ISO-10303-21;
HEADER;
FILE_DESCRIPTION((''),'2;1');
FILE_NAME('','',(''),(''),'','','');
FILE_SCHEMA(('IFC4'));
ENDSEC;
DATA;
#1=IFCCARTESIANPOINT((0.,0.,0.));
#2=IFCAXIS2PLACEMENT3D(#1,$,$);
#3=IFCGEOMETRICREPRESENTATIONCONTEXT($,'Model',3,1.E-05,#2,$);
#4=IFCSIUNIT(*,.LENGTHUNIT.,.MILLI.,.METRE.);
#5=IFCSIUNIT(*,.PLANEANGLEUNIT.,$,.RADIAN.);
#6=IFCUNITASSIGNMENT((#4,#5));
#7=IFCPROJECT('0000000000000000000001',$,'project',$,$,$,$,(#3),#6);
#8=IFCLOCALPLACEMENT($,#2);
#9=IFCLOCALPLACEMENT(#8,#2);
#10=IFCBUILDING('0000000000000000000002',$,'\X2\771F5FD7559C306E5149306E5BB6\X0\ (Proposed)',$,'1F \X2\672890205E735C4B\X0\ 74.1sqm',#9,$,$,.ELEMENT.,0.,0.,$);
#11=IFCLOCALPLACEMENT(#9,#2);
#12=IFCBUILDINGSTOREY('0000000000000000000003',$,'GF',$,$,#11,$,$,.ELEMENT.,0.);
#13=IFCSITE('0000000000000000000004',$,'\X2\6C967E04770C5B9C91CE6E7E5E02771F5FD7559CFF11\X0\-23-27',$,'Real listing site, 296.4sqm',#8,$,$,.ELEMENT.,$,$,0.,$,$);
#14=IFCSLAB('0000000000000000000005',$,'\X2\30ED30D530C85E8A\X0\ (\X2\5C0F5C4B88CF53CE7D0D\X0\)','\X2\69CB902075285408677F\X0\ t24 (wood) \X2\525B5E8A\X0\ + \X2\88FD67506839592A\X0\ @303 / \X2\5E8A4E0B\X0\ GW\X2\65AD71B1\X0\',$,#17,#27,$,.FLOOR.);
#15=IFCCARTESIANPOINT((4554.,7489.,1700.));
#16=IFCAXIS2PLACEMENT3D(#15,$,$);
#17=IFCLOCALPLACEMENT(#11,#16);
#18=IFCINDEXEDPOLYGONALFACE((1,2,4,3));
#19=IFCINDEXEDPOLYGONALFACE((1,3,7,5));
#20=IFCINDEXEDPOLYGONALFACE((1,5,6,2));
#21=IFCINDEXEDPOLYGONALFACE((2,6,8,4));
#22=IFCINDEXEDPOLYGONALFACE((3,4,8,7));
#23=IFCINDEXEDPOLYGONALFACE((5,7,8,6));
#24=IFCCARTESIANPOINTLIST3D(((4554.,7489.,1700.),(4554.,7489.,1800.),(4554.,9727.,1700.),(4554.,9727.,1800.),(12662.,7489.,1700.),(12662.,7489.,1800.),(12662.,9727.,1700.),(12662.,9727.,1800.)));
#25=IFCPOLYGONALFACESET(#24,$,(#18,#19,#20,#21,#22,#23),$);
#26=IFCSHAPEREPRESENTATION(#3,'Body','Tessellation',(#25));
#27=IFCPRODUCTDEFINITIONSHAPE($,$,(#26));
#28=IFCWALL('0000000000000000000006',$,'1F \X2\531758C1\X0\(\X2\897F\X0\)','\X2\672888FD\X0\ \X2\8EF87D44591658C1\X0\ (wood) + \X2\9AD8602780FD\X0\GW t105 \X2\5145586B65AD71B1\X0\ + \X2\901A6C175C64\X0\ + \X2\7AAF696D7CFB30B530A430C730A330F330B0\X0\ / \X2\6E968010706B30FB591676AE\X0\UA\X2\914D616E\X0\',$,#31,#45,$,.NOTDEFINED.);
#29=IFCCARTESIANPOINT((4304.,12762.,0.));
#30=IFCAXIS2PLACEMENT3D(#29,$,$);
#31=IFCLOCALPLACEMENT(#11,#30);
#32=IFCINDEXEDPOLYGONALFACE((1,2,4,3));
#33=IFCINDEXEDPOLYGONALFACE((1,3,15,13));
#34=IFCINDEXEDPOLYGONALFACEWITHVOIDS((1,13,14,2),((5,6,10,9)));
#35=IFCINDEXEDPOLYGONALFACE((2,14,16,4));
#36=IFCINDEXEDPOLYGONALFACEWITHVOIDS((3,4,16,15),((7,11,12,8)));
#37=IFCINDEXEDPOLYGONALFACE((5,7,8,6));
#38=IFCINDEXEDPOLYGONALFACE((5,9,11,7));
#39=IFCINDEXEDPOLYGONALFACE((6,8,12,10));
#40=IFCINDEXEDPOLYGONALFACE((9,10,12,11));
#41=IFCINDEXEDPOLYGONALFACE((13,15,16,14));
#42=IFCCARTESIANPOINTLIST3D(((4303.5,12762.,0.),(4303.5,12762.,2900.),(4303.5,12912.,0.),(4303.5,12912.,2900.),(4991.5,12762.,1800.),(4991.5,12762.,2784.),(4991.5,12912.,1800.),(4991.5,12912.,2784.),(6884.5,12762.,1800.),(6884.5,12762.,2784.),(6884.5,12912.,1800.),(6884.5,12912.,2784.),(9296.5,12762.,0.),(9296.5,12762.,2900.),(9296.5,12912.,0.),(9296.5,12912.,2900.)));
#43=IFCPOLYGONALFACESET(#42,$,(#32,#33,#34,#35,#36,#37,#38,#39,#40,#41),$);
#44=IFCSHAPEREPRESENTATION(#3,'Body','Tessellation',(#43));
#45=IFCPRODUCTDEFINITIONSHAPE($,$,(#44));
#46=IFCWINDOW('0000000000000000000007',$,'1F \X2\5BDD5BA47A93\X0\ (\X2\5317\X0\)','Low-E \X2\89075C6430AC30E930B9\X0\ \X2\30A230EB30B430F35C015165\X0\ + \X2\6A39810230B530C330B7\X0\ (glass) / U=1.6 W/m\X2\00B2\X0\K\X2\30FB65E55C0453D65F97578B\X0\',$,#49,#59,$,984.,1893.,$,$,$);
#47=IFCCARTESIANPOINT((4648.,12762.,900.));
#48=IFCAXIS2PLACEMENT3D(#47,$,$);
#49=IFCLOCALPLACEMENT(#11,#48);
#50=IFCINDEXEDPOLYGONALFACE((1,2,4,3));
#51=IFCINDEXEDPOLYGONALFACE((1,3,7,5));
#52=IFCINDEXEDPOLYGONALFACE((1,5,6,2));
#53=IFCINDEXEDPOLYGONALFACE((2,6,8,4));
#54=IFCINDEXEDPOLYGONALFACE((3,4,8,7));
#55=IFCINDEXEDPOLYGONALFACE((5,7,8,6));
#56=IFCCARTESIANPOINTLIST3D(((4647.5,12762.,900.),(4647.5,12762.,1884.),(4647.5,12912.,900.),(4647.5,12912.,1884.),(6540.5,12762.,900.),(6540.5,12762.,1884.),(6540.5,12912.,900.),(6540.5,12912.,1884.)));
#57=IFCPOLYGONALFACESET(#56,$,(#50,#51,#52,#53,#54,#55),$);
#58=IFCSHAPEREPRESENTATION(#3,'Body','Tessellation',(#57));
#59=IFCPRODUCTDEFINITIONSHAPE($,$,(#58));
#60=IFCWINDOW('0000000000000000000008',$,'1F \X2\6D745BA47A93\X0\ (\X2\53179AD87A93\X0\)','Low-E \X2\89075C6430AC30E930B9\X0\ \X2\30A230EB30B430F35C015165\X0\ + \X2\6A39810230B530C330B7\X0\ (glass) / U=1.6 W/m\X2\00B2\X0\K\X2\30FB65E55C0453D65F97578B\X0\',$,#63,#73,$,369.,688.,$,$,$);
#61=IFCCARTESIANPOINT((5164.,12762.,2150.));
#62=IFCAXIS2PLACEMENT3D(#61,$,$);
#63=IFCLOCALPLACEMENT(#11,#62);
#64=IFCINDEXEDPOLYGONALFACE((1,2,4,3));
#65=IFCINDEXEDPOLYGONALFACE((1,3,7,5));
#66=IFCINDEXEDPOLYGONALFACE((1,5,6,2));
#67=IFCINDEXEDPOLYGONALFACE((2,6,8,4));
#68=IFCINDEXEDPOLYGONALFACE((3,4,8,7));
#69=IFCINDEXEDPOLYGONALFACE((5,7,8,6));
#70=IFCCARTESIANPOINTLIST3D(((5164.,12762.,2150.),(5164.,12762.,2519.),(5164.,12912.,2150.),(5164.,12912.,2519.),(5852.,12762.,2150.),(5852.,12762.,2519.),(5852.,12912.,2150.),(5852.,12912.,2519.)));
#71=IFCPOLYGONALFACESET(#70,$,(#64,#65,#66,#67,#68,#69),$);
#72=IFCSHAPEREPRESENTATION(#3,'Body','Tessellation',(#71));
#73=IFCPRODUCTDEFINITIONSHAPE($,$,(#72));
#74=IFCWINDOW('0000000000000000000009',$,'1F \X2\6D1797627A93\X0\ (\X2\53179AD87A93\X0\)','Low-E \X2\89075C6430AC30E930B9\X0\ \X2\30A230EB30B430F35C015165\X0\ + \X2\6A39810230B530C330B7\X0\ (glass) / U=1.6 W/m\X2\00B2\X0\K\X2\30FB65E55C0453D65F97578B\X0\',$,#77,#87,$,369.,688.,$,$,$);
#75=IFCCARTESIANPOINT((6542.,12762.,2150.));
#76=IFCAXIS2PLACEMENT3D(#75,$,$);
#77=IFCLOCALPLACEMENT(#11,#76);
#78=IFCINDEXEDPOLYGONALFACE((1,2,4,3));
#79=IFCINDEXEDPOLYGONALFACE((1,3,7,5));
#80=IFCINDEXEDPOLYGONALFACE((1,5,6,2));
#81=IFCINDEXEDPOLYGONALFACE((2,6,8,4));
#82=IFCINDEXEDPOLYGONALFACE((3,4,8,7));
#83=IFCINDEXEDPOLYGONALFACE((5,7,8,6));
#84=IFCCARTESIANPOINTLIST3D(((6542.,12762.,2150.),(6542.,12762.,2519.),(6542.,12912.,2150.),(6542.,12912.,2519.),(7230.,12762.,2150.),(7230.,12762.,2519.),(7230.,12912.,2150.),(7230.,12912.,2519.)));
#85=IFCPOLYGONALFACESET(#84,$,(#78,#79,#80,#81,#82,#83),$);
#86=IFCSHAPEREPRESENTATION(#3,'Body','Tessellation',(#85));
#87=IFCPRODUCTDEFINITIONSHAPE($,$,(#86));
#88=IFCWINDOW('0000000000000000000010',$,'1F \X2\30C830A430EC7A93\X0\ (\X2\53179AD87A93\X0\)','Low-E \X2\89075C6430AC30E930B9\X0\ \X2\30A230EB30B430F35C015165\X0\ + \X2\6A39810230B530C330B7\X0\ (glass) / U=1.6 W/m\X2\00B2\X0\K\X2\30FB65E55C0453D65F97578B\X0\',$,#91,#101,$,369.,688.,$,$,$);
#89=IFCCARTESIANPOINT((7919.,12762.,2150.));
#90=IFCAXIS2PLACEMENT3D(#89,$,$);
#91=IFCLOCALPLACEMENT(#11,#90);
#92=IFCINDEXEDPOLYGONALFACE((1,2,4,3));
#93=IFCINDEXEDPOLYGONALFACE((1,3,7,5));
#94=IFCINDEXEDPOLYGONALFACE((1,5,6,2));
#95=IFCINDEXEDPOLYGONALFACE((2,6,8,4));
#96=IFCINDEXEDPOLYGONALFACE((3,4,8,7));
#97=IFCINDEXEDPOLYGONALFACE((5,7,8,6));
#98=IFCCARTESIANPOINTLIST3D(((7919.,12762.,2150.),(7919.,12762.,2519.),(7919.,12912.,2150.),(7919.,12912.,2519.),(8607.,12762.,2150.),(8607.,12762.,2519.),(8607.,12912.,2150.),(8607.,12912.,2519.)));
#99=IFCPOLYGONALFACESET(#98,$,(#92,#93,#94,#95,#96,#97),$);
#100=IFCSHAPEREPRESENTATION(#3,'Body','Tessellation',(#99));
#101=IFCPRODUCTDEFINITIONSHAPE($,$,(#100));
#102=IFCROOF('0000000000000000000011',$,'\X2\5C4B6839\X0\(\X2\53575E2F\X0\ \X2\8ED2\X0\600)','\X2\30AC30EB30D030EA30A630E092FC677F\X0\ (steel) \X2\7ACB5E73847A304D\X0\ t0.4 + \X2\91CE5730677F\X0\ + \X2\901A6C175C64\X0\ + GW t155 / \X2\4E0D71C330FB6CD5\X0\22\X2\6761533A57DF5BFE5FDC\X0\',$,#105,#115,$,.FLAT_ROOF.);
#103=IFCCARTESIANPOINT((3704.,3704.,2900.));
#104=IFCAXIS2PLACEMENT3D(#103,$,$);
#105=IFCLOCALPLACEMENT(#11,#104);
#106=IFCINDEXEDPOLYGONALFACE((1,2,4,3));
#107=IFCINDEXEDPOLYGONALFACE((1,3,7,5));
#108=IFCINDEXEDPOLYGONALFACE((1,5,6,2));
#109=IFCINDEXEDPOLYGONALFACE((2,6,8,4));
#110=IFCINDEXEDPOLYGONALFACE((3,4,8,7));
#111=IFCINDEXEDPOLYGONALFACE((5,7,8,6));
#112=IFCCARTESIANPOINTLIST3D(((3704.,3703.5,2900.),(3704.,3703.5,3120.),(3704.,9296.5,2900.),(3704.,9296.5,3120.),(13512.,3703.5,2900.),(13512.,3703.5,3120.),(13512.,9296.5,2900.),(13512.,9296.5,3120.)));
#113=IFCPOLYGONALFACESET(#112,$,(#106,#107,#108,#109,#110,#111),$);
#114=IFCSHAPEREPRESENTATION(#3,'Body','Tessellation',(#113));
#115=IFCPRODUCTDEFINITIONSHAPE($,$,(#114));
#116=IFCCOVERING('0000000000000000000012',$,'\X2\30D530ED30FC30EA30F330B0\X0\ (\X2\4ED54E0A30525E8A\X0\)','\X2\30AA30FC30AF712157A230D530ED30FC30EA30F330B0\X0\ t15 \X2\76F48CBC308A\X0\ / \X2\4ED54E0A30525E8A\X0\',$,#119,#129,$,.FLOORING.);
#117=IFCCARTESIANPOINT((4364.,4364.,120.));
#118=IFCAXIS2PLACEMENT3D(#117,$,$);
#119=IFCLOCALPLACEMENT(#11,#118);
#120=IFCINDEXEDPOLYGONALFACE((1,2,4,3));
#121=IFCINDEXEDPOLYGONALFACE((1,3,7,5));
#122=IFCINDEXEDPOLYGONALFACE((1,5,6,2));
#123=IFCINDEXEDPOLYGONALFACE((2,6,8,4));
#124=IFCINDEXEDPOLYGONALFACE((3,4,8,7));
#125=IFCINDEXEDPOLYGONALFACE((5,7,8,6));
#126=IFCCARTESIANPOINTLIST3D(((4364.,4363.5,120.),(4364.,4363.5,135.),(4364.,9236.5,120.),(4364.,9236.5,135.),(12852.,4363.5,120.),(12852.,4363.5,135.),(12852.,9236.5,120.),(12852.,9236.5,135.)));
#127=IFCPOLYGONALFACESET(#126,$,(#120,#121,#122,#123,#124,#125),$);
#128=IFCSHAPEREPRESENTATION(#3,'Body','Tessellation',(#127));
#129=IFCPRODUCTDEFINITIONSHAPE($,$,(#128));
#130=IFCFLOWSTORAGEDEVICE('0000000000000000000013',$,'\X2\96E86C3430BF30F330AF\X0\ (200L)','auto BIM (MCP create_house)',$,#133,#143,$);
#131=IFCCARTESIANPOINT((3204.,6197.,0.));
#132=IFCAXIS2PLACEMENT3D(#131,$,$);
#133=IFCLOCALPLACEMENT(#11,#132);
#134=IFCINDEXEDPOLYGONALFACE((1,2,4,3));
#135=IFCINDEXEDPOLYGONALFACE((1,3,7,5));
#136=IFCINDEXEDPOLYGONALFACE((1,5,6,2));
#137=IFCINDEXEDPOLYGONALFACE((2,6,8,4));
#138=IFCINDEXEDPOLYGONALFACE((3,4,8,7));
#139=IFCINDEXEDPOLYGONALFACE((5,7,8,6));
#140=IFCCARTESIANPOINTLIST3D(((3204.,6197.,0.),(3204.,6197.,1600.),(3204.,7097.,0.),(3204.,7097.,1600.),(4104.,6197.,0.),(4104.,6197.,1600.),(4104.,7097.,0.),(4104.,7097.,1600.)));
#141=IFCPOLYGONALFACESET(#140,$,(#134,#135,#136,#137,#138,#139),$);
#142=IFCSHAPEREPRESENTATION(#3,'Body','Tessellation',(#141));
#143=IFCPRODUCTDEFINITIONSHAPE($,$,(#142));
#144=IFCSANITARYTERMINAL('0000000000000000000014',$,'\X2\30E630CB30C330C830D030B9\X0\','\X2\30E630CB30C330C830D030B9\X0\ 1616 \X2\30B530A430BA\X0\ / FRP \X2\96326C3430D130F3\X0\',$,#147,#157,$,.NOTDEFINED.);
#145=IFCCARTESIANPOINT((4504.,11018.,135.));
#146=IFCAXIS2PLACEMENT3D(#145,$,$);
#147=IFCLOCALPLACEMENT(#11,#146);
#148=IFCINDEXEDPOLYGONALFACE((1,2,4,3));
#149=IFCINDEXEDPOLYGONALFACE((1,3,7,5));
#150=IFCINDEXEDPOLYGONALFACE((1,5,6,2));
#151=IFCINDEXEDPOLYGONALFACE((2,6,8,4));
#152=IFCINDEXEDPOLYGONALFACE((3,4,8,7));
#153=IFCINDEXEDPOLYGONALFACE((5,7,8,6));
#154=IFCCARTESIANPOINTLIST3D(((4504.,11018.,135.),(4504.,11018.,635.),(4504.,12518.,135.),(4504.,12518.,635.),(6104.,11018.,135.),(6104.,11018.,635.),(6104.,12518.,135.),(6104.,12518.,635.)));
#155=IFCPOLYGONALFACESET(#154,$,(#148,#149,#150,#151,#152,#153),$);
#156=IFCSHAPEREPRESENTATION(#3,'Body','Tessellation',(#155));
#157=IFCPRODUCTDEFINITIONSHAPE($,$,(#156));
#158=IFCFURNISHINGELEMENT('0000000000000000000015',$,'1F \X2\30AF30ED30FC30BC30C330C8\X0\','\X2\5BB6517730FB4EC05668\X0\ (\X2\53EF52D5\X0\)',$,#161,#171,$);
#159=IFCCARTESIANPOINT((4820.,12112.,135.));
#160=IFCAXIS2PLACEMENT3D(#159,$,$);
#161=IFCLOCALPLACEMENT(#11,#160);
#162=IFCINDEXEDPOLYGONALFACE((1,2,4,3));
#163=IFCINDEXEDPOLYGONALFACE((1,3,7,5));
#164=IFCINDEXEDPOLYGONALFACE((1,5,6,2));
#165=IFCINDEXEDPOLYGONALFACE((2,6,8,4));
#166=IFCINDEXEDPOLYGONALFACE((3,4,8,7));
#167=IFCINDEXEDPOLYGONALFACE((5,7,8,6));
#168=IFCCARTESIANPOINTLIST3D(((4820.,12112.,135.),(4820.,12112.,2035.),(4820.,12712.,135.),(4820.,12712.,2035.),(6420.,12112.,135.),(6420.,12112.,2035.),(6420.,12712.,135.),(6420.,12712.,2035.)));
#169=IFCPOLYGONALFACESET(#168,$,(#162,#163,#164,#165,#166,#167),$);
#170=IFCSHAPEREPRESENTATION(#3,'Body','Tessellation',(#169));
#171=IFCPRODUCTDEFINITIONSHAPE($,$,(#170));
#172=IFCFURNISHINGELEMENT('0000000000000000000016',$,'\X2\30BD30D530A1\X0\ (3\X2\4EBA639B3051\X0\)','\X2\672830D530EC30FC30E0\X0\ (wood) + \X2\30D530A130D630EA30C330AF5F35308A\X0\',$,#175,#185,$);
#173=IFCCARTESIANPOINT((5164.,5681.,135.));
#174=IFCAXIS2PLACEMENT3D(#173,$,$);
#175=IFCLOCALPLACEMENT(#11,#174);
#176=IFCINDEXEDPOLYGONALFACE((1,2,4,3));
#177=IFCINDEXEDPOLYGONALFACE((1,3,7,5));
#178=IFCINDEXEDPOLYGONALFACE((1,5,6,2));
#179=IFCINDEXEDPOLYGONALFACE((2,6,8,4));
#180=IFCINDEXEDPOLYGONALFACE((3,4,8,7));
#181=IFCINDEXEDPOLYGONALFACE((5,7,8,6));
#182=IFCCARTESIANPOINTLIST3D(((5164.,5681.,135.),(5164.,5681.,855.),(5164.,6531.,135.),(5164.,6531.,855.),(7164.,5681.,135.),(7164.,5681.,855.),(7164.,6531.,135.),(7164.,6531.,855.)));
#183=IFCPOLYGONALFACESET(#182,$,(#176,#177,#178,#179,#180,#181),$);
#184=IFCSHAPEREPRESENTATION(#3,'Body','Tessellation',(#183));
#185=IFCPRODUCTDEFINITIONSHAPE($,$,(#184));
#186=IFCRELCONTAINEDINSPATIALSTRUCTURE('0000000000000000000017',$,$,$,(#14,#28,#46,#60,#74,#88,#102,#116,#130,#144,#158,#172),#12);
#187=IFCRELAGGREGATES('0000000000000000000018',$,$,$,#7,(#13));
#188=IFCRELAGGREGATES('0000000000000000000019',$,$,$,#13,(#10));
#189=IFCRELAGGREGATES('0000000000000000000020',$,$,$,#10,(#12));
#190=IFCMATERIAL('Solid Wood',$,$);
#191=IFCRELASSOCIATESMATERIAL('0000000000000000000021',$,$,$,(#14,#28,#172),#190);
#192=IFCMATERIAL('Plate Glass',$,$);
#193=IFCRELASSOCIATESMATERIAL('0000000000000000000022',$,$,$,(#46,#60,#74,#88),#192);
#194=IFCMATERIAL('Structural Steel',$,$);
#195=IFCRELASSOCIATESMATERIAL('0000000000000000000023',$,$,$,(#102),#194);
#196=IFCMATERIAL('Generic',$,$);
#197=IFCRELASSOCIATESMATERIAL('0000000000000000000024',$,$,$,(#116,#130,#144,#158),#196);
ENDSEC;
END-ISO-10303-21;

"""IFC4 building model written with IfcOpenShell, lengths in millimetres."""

from ifc_helpers import new_model, si_unit, frame, frame_2d, origin, place, context, project, spatial, rectangle, extrude, material, element, fill, save


model = new_model("IFC4")

# Units and contexts
model_context = context("Model", 3, precision=1e-05, world=origin())
ifc_project = project(units=[si_unit("LENGTHUNIT", "METRE", prefix="MILLI"), si_unit("PLANEANGLEUNIT", "RADIAN")], contexts=[model_context])

# Site, building, storey
site_placement = place(None, origin())
site = spatial("IfcSite", under=ifc_project, at=site_placement, Name="沖縄県宜野湾市真志喜１-23-27", ObjectType="Real listing site, 296.4sqm", CompositionType="ELEMENT", RefElevation=0.0)
building_placement = place(site_placement, origin())
building = spatial("IfcBuilding", under=site, at=building_placement, Name="真志喜の光の家 (Proposed)", ObjectType="1F 木造平屋 74.1sqm", CompositionType="ELEMENT", ElevationOfRefHeight=0.0, ElevationOfTerrain=0.0)
storey_placement = place(building_placement, origin())
storey = spatial("IfcBuildingStorey", under=building, at=storey_placement, Name="GF", CompositionType="ELEMENT", Elevation=0.0)

# Slab
ifc_material_1 = material(Name="Solid Wood")
slab_1_placement = place(storey_placement, frame((4554.0, 7489.0, 1700.0)))
element("IfcSlab", 1, at=slab_1_placement, inside=storey, material=ifc_material_1, Name="ロフト床 (小屋裏収納)", Description="構造用合板 t24 (wood) 剛床 + 製材根太 @303 / 床下 GW断熱", PredefinedType="FLOOR", context=model_context, shape_type="SweptSolid", body=[
    extrude(rectangle(XDim=8108.0, YDim=2238.0, at=frame_2d((4054.0, 1119.0))), frame((4554.0, 7489.0, 1700.0)), (0.0, 0.0, 1.0), 100.0),
])

# Shared definitions
ifc_material_2 = material(Name="Plate Glass")

# Wall, openings, windows
wall_1_placement = place(storey_placement, frame((4304.0, 12762.0, 0.0)))
wall_1 = element("IfcWall", 2, at=wall_1_placement, inside=storey, material=ifc_material_1, Name="1F 北壁(西)", Description="木製 軸組外壁 (wood) + 高性能GW t105 充填断熱 + 通気層 + 窯業系サイディング / 準耐火・外皮UA配慮", PredefinedType="NOTDEFINED", context=model_context, shape_type="SweptSolid", body=[
    extrude(rectangle(XDim=4993.0, YDim=150.0, at=frame_2d((2496.0, 75.0))), frame((4304.0, 12762.0, 0.0)), (0.0, 0.0, 1.0), 2900.0),
])
opening_1_placement = place(storey_placement, frame((4648.0, 12762.0, 900.0)))
opening_1 = element("IfcOpeningElement", 3, at=opening_1_placement, cuts=wall_1, PredefinedType="NOTDEFINED", context=model_context, shape_type="SweptSolid", body=[
    extrude(rectangle(XDim=1893.0, YDim=150.0, at=frame_2d((946.0, 75.0))), frame((4648.0, 12762.0, 900.0)), (0.0, 0.0, 1.0), 984.0),
])
opening_2_placement = place(storey_placement, frame((5164.0, 12762.0, 2150.0)))
opening_2 = element("IfcOpeningElement", 4, at=opening_2_placement, cuts=wall_1, PredefinedType="NOTDEFINED", context=model_context, shape_type="SweptSolid", body=[
    extrude(rectangle(XDim=688.0, YDim=150.0, at=frame_2d((344.0, 75.0))), frame((5164.0, 12762.0, 2150.0)), (0.0, 0.0, 1.0), 369.0),
])
opening_3_placement = place(storey_placement, frame((6542.0, 12762.0, 2150.0)))
opening_3 = element("IfcOpeningElement", 5, at=opening_3_placement, cuts=wall_1, PredefinedType="NOTDEFINED", context=model_context, shape_type="SweptSolid", body=[
    extrude(rectangle(XDim=688.0, YDim=150.0, at=frame_2d((344.0, 75.0))), frame((6542.0, 12762.0, 2150.0)), (0.0, 0.0, 1.0), 369.0),
])
opening_4_placement = place(storey_placement, frame((7919.0, 12762.0, 2150.0)))
opening_4 = element("IfcOpeningElement", 6, at=opening_4_placement, cuts=wall_1, PredefinedType="NOTDEFINED", context=model_context, shape_type="SweptSolid", body=[
    extrude(rectangle(XDim=688.0, YDim=150.0, at=frame_2d((344.0, 75.0))), frame((7919.0, 12762.0, 2150.0)), (0.0, 0.0, 1.0), 369.0),
])
window_1_placement = place(storey_placement, frame((4648.0, 12762.0, 900.0)))
window_1 = element("IfcWindow", 7, at=window_1_placement, inside=storey, material=ifc_material_2, Name="1F 寝室窓 (北)", Description="Low-E 複層ガラス アルゴン封入 + 樹脂サッシ (glass) / U=1.6 W/m²K・日射取得型", OverallHeight=984.0, OverallWidth=1893.0, context=model_context, shape_type="SweptSolid", body=[
    extrude(rectangle(XDim=1893.0, YDim=150.0, at=frame_2d((946.0, 75.0))), frame((4648.0, 12762.0, 900.0)), (0.0, 0.0, 1.0), 984.0),
])
fill(opening_1, window_1)
window_2_placement = place(storey_placement, frame((5164.0, 12762.0, 2150.0)))
window_2 = element("IfcWindow", 8, at=window_2_placement, inside=storey, material=ifc_material_2, Name="1F 浴室窓 (北高窓)", Description="Low-E 複層ガラス アルゴン封入 + 樹脂サッシ (glass) / U=1.6 W/m²K・日射取得型", OverallHeight=369.0, OverallWidth=688.0, context=model_context, shape_type="SweptSolid", body=[
    extrude(rectangle(XDim=688.0, YDim=150.0, at=frame_2d((344.0, 75.0))), frame((5164.0, 12762.0, 2150.0)), (0.0, 0.0, 1.0), 369.0),
])
fill(opening_2, window_2)
window_3_placement = place(storey_placement, frame((6542.0, 12762.0, 2150.0)))
window_3 = element("IfcWindow", 9, at=window_3_placement, inside=storey, material=ifc_material_2, Name="1F 洗面窓 (北高窓)", Description="Low-E 複層ガラス アルゴン封入 + 樹脂サッシ (glass) / U=1.6 W/m²K・日射取得型", OverallHeight=369.0, OverallWidth=688.0, context=model_context, shape_type="SweptSolid", body=[
    extrude(rectangle(XDim=688.0, YDim=150.0, at=frame_2d((344.0, 75.0))), frame((6542.0, 12762.0, 2150.0)), (0.0, 0.0, 1.0), 369.0),
])
fill(opening_3, window_3)
window_4_placement = place(storey_placement, frame((7919.0, 12762.0, 2150.0)))
window_4 = element("IfcWindow", 10, at=window_4_placement, inside=storey, material=ifc_material_2, Name="1F トイレ窓 (北高窓)", Description="Low-E 複層ガラス アルゴン封入 + 樹脂サッシ (glass) / U=1.6 W/m²K・日射取得型", OverallHeight=369.0, OverallWidth=688.0, context=model_context, shape_type="SweptSolid", body=[
    extrude(rectangle(XDim=688.0, YDim=150.0, at=frame_2d((344.0, 75.0))), frame((7919.0, 12762.0, 2150.0)), (0.0, 0.0, 1.0), 369.0),
])
fill(opening_4, window_4)

# Roof
ifc_material_3 = material(Name="Structural Steel")
roof_1_placement = place(storey_placement, frame((3704.0, 3704.0, 2900.0)))
element("IfcRoof", 11, at=roof_1_placement, inside=storey, material=ifc_material_3, Name="屋根(南帯 軒600)", Description="ガルバリウム鋼板 (steel) 立平葺き t0.4 + 野地板 + 通気層 + GW t155 / 不燃・法22条区域対応", PredefinedType="FLAT_ROOF", context=model_context, shape_type="SweptSolid", body=[
    extrude(rectangle(XDim=9808.0, YDim=5593.0, at=frame_2d((4904.0, 2796.0))), frame((3704.0, 3704.0, 2900.0)), (0.0, 0.0, 1.0), 220.0),
])

# Covering
ifc_material_4 = material(Name="Generic")
covering_1_placement = place(storey_placement, frame((4364.0, 4364.0, 120.0)))
element("IfcCovering", 12, at=covering_1_placement, inside=storey, material=ifc_material_4, Name="フローリング (仕上げ床)", Description="オーク無垢フローリング t15 直貼り / 仕上げ床", PredefinedType="FLOORING", context=model_context, shape_type="SweptSolid", body=[
    extrude(rectangle(XDim=8488.0, YDim=4873.0, at=frame_2d((4244.0, 2436.0))), frame((4364.0, 4364.0, 120.0)), (0.0, 0.0, 1.0), 15.0),
])

# Flow storage device
flow_storage_device_placement = place(storey_placement, frame((3204.0, 6197.0, 0.0)))
element("IfcFlowStorageDevice", 13, at=flow_storage_device_placement, inside=storey, material=ifc_material_4, Name="雨水タンク (200L)", Description="auto BIM (MCP create_house)", context=model_context, shape_type="SweptSolid", body=[
    extrude(rectangle(XDim=900.0, YDim=900.0, at=frame_2d((450.0, 450.0))), frame((3204.0, 6197.0, 0.0)), (0.0, 0.0, 1.0), 1600.0),
])

# Sanitary terminal
sanitary_terminal_placement = place(storey_placement, frame((4504.0, 11018.0, 135.0)))
element("IfcSanitaryTerminal", 14, at=sanitary_terminal_placement, inside=storey, material=ifc_material_4, Name="ユニットバス", Description="ユニットバス 1616 サイズ / FRP 防水パン", PredefinedType="NOTDEFINED", context=model_context, shape_type="SweptSolid", body=[
    extrude(rectangle(XDim=1600.0, YDim=1500.0, at=frame_2d((800.0, 750.0))), frame((4504.0, 11018.0, 135.0)), (0.0, 0.0, 1.0), 500.0),
])

# Furnishing elements
furnishing_1_placement = place(storey_placement, frame((4820.0, 12112.0, 135.0)))
element("IfcFurnishingElement", 15, at=furnishing_1_placement, inside=storey, material=ifc_material_4, Name="1F クローゼット", Description="家具・什器 (可動)", context=model_context, shape_type="SweptSolid", body=[
    extrude(rectangle(XDim=1600.0, YDim=600.0, at=frame_2d((800.0, 300.0))), frame((4820.0, 12112.0, 135.0)), (0.0, 0.0, 1.0), 1900.0),
])
furnishing_2_placement = place(storey_placement, frame((5164.0, 5681.0, 135.0)))
element("IfcFurnishingElement", 16, at=furnishing_2_placement, inside=storey, material=ifc_material_1, Name="ソファ (3人掛け)", Description="木フレーム (wood) + ファブリック張り", context=model_context, shape_type="SweptSolid", body=[
    extrude(rectangle(XDim=2000.0, YDim=850.0, at=frame_2d((1000.0, 425.0))), frame((5164.0, 5681.0, 135.0)), (0.0, 0.0, 1.0), 720.0),
])

save(model, "model.ifc")
